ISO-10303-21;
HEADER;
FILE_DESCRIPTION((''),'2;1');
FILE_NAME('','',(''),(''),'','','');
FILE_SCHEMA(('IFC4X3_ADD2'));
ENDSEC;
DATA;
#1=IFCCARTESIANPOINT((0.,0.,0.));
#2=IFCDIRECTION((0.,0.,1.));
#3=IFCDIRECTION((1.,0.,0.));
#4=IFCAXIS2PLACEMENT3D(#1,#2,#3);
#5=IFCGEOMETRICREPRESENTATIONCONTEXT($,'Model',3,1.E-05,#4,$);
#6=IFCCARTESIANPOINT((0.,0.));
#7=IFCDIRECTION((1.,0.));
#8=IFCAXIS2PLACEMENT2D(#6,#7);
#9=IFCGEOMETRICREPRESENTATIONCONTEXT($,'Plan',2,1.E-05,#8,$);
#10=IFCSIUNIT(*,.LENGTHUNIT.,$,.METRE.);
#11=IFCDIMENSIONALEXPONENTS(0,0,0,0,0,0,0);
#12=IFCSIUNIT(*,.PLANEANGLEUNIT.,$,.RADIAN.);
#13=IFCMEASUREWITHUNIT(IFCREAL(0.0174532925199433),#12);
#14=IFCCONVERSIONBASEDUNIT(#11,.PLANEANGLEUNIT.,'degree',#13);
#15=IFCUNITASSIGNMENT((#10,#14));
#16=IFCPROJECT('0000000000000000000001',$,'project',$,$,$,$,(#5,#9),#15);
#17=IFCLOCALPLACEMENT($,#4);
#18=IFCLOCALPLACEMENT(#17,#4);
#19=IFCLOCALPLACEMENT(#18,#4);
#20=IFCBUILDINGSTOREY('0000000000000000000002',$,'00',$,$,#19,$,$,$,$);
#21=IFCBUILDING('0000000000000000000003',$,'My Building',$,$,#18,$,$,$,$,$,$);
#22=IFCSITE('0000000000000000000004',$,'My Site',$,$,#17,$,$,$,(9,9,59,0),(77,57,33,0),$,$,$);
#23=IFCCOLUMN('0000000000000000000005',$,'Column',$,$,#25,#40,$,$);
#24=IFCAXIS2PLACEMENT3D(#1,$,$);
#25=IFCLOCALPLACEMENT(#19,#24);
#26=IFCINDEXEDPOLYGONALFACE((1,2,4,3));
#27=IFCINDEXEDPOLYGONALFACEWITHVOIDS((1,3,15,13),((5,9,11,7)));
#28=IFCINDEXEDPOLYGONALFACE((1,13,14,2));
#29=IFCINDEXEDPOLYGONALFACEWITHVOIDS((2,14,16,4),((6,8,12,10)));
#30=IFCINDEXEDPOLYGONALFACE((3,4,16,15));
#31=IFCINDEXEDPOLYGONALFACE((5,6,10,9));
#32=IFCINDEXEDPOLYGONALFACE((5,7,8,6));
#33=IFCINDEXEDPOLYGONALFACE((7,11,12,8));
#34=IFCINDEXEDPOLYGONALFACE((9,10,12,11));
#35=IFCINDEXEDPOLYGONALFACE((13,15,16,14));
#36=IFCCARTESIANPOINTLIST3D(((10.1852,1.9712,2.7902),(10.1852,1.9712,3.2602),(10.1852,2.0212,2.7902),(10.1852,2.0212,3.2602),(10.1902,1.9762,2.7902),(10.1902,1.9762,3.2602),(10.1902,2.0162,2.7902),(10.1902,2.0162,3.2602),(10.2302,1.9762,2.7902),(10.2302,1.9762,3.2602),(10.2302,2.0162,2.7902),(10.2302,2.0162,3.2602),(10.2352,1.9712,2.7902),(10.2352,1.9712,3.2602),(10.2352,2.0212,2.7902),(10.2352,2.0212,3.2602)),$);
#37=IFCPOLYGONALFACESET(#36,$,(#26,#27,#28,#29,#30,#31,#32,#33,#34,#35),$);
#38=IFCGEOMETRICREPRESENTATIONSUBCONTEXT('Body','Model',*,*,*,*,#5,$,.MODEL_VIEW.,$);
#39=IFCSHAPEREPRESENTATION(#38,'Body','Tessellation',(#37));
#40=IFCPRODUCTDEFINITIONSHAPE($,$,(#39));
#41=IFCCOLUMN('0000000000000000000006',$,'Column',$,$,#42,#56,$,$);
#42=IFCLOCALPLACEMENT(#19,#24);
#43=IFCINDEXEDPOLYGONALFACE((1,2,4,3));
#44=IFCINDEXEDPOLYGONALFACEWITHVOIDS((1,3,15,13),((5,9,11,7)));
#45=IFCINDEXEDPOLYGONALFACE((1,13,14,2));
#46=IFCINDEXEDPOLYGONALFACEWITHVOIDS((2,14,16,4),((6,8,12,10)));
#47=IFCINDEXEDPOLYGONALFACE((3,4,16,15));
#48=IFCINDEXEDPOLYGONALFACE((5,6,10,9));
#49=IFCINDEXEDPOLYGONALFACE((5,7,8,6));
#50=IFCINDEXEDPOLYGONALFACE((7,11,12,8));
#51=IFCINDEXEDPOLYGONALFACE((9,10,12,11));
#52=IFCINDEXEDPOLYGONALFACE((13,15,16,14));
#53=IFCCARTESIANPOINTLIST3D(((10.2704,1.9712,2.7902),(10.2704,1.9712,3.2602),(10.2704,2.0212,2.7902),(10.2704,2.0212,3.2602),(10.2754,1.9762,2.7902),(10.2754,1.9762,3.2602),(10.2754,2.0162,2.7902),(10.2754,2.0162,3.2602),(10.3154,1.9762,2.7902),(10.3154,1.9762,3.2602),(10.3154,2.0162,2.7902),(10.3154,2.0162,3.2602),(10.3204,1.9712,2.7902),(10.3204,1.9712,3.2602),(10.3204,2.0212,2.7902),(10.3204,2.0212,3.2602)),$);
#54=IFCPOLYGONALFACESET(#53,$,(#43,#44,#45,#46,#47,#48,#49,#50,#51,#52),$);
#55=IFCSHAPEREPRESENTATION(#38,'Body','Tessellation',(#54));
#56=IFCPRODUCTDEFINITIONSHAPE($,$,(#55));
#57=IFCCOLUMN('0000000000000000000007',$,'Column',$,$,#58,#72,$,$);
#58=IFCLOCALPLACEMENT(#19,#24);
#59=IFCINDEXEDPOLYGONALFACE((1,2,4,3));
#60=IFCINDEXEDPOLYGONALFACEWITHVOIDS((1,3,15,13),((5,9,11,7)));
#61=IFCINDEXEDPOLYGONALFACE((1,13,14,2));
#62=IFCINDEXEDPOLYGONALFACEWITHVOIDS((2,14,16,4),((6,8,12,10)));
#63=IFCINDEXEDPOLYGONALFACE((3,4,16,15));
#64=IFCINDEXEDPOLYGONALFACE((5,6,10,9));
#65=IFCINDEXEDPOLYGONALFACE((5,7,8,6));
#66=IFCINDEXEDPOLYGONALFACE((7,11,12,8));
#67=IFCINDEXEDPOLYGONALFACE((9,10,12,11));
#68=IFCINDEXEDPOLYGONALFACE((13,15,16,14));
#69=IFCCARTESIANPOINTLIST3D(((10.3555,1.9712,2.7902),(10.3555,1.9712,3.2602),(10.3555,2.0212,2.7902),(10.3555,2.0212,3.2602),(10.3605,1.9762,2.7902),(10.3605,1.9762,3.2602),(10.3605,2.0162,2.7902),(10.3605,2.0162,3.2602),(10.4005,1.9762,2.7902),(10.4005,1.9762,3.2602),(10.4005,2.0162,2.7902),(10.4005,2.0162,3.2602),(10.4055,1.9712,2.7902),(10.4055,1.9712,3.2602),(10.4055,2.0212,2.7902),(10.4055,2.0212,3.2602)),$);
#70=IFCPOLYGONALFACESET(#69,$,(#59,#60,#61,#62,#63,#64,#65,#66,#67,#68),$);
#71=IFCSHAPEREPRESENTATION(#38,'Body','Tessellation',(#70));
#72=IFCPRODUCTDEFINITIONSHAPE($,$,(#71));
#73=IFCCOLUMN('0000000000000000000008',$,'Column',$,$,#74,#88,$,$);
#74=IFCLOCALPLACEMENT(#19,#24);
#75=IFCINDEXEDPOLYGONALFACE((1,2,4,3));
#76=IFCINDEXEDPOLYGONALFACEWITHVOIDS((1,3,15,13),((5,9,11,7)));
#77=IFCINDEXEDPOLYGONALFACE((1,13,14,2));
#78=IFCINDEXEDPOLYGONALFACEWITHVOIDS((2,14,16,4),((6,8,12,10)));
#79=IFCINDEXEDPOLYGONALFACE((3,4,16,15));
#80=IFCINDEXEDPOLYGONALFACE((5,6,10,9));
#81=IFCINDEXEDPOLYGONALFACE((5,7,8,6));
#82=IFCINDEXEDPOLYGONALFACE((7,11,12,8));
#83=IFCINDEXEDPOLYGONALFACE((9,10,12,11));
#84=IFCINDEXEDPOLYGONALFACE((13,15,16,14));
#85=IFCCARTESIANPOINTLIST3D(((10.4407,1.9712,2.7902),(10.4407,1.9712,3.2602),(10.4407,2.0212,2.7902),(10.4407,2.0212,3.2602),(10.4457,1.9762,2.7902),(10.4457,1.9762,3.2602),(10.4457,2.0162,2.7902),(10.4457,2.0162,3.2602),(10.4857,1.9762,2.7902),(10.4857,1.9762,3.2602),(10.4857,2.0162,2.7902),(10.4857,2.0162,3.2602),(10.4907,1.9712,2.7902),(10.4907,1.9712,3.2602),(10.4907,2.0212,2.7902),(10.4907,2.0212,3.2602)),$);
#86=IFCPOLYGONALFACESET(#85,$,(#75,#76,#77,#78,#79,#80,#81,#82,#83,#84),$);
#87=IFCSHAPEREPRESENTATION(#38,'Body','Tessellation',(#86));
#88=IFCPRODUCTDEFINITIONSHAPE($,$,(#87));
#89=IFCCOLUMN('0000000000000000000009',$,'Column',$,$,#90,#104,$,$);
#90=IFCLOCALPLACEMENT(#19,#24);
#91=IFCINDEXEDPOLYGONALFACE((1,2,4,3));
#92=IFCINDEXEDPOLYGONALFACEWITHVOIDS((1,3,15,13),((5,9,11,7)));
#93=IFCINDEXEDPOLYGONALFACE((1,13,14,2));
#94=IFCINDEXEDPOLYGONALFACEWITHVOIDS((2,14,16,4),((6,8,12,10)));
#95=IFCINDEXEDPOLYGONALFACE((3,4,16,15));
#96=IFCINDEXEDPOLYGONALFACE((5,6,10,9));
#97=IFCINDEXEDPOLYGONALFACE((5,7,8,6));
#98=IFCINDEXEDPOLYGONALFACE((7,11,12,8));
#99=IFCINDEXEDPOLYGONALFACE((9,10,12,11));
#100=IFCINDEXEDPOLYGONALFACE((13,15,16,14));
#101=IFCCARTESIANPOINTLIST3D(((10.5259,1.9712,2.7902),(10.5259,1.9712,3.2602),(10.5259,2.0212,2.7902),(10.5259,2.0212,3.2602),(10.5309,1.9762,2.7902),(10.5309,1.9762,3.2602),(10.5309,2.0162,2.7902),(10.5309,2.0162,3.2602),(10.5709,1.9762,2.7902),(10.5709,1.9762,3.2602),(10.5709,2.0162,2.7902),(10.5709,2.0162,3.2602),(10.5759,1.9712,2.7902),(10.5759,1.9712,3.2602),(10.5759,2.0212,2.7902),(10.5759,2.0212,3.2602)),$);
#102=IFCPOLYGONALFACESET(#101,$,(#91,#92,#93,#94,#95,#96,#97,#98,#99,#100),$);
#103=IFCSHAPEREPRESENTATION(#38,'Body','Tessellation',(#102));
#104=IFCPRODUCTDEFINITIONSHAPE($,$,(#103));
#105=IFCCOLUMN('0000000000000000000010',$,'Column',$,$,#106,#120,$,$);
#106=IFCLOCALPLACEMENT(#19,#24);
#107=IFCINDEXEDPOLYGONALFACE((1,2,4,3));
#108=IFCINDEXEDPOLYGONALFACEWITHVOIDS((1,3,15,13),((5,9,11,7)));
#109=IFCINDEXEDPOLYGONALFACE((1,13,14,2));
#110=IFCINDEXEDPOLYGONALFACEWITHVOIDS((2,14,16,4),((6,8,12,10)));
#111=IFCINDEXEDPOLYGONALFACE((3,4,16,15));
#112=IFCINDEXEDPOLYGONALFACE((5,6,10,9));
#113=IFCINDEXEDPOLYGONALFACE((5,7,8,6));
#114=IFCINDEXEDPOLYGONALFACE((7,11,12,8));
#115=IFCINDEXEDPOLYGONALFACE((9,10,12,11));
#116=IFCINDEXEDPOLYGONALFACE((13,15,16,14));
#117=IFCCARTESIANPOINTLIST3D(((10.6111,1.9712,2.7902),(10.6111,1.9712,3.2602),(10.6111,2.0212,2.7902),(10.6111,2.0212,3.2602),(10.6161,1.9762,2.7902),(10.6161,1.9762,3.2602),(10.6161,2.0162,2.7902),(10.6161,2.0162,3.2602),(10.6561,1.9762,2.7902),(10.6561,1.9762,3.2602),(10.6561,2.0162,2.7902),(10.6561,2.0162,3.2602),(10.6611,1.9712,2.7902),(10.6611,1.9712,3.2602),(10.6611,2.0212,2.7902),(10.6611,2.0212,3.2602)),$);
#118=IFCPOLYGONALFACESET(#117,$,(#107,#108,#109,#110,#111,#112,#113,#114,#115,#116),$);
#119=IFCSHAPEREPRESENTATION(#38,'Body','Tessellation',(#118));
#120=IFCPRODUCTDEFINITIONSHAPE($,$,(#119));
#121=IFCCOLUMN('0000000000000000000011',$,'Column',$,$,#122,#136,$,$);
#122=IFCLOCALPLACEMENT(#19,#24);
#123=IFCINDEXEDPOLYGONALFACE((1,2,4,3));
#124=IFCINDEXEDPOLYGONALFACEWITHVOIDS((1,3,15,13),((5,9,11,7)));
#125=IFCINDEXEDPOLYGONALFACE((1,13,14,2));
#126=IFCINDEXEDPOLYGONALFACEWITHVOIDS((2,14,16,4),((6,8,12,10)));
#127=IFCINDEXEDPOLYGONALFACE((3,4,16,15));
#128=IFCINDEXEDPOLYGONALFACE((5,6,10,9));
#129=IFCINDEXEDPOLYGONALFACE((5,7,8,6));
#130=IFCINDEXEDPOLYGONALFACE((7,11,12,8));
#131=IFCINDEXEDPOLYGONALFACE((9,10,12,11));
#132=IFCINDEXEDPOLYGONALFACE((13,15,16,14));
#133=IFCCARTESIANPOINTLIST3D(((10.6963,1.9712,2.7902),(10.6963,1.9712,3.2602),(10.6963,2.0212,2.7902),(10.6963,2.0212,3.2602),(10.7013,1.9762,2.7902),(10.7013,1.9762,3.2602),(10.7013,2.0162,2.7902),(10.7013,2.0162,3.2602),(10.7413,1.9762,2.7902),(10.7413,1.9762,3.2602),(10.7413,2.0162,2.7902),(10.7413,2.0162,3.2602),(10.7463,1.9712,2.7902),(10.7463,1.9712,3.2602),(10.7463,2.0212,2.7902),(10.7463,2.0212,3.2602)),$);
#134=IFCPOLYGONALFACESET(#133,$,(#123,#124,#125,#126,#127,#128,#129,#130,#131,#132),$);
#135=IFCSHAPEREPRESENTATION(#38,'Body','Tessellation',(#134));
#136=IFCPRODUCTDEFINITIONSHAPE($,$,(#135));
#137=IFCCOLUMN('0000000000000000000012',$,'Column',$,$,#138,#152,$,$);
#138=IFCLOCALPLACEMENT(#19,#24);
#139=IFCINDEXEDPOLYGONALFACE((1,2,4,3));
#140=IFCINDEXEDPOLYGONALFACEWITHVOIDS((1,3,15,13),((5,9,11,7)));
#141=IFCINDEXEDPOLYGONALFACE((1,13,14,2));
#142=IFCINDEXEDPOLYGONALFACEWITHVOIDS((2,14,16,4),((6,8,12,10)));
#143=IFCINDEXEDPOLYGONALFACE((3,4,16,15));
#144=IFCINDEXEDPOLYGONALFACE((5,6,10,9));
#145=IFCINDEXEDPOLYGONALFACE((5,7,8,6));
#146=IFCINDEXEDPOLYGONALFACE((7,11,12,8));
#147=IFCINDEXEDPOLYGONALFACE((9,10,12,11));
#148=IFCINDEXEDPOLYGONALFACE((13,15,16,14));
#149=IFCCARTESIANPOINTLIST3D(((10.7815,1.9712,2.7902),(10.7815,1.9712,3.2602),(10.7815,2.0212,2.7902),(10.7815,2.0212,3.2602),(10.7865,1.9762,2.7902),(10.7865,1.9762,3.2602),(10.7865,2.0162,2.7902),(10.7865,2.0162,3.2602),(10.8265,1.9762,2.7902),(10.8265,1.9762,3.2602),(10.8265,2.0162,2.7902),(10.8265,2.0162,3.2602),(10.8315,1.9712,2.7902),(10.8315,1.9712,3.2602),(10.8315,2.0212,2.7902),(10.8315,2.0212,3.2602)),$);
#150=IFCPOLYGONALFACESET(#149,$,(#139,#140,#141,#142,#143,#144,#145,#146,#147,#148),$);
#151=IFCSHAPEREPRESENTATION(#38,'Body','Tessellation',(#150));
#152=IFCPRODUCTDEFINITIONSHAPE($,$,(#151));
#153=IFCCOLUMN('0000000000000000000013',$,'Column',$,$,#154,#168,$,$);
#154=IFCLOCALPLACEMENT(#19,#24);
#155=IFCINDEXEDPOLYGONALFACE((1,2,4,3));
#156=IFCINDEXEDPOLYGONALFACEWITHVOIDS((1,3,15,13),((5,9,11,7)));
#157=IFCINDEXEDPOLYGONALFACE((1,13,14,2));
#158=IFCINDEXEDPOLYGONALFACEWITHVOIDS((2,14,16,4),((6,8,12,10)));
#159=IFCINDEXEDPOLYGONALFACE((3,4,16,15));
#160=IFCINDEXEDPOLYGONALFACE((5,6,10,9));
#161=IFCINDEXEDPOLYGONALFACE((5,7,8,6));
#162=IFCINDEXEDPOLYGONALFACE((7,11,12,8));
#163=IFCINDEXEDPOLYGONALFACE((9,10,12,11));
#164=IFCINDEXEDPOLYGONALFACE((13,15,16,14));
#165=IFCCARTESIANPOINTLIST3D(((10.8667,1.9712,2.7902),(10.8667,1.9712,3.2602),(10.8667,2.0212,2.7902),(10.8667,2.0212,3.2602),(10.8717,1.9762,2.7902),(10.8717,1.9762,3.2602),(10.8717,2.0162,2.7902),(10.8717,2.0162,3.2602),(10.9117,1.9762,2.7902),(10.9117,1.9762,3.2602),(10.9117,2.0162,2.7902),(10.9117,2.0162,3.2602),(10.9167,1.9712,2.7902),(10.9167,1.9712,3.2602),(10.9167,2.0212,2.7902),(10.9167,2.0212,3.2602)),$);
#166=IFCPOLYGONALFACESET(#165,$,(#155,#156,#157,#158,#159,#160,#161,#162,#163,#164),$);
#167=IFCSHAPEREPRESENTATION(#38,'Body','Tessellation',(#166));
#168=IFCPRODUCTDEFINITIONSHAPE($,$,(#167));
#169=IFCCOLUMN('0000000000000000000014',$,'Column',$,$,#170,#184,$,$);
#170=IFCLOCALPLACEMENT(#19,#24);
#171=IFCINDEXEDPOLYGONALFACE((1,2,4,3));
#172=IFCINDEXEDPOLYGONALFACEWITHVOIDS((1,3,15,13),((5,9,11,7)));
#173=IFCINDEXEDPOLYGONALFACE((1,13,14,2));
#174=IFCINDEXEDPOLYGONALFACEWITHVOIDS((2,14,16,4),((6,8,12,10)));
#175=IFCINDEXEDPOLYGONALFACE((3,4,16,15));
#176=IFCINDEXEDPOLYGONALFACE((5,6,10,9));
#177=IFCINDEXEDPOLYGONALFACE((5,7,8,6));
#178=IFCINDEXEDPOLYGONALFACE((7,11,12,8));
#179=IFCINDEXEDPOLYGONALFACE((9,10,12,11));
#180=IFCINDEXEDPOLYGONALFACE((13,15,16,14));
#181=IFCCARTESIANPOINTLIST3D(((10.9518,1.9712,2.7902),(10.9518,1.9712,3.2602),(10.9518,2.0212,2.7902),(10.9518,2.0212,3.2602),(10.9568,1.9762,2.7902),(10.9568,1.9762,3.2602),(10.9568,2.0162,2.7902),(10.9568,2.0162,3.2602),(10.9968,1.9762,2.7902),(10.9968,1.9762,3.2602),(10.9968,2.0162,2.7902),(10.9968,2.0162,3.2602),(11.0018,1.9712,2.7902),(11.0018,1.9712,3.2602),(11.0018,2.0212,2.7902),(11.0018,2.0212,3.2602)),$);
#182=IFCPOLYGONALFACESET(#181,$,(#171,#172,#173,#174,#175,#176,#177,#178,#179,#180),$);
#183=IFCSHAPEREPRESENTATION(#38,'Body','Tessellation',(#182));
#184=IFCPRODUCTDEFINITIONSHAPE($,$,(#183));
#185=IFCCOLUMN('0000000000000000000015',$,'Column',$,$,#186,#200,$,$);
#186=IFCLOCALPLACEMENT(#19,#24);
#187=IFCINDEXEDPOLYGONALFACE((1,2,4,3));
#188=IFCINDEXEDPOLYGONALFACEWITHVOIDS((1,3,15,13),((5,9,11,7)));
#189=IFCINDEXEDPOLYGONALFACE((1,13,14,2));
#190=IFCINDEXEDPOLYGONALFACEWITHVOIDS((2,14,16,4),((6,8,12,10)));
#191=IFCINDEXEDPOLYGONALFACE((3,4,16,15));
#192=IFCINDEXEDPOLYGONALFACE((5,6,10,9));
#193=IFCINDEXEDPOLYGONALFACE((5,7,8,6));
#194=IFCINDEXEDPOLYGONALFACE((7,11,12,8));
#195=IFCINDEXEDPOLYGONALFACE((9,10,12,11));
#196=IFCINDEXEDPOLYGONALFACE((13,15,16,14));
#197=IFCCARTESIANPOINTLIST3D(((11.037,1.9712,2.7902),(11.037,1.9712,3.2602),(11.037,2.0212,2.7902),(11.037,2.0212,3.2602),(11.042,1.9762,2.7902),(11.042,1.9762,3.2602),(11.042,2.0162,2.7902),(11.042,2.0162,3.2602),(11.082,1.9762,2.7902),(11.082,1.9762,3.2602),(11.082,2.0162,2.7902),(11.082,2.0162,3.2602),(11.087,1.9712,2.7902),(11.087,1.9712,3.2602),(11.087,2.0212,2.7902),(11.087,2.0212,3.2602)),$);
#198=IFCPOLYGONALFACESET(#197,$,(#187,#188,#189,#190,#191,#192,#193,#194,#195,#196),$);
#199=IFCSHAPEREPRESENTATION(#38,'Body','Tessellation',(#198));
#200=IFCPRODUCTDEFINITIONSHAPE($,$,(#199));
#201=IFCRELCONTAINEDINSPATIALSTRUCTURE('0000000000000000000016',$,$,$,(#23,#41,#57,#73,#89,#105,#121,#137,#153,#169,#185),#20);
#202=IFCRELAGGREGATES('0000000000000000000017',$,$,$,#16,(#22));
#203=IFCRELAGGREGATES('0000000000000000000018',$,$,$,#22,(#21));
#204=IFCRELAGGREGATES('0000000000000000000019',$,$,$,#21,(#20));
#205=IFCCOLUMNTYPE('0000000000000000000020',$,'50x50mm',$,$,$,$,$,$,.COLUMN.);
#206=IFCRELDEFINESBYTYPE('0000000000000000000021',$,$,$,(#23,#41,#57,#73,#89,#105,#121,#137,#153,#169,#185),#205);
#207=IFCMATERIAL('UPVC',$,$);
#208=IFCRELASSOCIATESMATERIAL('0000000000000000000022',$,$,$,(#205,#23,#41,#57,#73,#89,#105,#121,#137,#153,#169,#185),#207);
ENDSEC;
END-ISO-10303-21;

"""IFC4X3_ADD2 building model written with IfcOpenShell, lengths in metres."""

from ifc_helpers import new_model, entity, si_unit, converted_unit, frame, origin_with_axes, origin_2d_with_axis, place, context, subcontext, project, spatial, hollow_rectangle, extrude, material, material_profile, profile_set, profile_usage, type_object, element, save


model = new_model("IFC4X3_ADD2")

# Units and contexts
model_context = context("Model", 3, precision=1e-05, world=origin_with_axes())
plan_context = context("Plan", 2, precision=1e-05, world=origin_2d_with_axis())
body_context = subcontext(model_context, "Body", "Model", "MODEL_VIEW")
ifc_project = project(units=[si_unit("LENGTHUNIT", "METRE"), converted_unit("PLANEANGLEUNIT", "degree", entity("IfcReal", 0.0174532925199433), si_unit("PLANEANGLEUNIT", "RADIAN"), dimensions=[0, 0, 0, 0, 0, 0, 0])], contexts=[model_context, plan_context])

# Site, building, storey
site_placement = place(None, origin_with_axes())
site = spatial("IfcSite", under=ifc_project, at=site_placement, Name="My Site", RefLatitude=(9, 9, 59, 0), RefLongitude=(77, 57, 33, 0))
building_placement = place(site_placement, origin_with_axes())
building = spatial("IfcBuilding", under=site, at=building_placement, Name="My Building")
storey_placement = place(building_placement, origin_with_axes())
storey = spatial("IfcBuildingStorey", under=building, at=storey_placement, Name="00")

# Columns
ifc_material_1 = material(Name="UPVC")
ifc_material_profile_1 = material_profile(ifc_material_1, hollow_rectangle(XDim=0.05, YDim=0.05, WallThickness=0.005))
ifc_profile_set_1 = profile_set([ifc_material_profile_1])
ifc_profile_usage_1 = profile_usage(ifc_profile_set_1, cardinal=5)
column_type = type_object("IfcColumnType", Name="50x50mm", PredefinedType="COLUMN", material=ifc_profile_set_1)
column_1_placement = place(storey_placement, frame((10.2102, 1.9962, 2.7902), z_axis=(0.0, 0.0, 1.0), x_axis=(1.0, 0.0, 0.0)))
element("IfcColumn", 1, at=column_1_placement, inside=storey, type_object=column_type, material=ifc_profile_usage_1, Name="Column", context=body_context, shape_type="SweptSolid", body=[
    extrude(hollow_rectangle(XDim=0.05, YDim=0.05, WallThickness=0.005), origin_with_axes(), (0.0, 0.0, 1.0), 0.47),
])
ifc_profile_usage_2 = profile_usage(ifc_profile_set_1, cardinal=5)
column_2_placement = place(storey_placement, frame((10.2954, 1.9962, 2.7902), z_axis=(0.0, 0.0, 1.0), x_axis=(1.0, 0.0, 0.0)))
element("IfcColumn", 2, at=column_2_placement, inside=storey, type_object=column_type, material=ifc_profile_usage_2, Name="Column", context=body_context, shape_type="SweptSolid", body=[
    extrude(hollow_rectangle(XDim=0.05, YDim=0.05, WallThickness=0.005), origin_with_axes(), (0.0, 0.0, 1.0), 0.47),
])
ifc_profile_usage_3 = profile_usage(ifc_profile_set_1, cardinal=5)
column_3_placement = place(storey_placement, frame((10.3805, 1.9962, 2.7902), z_axis=(0.0, 0.0, 1.0), x_axis=(1.0, 0.0, 0.0)))
element("IfcColumn", 3, at=column_3_placement, inside=storey, type_object=column_type, material=ifc_profile_usage_3, Name="Column", context=body_context, shape_type="SweptSolid", body=[
    extrude(hollow_rectangle(XDim=0.05, YDim=0.05, WallThickness=0.005), origin_with_axes(), (0.0, 0.0, 1.0), 0.47),
])
ifc_profile_usage_4 = profile_usage(ifc_profile_set_1, cardinal=5)
column_4_placement = place(storey_placement, frame((10.4657, 1.9962, 2.7902), z_axis=(0.0, 0.0, 1.0), x_axis=(1.0, 0.0, 0.0)))
element("IfcColumn", 4, at=column_4_placement, inside=storey, type_object=column_type, material=ifc_profile_usage_4, Name="Column", context=body_context, shape_type="SweptSolid", body=[
    extrude(hollow_rectangle(XDim=0.05, YDim=0.05, WallThickness=0.005), origin_with_axes(), (0.0, 0.0, 1.0), 0.47),
])
ifc_profile_usage_5 = profile_usage(ifc_profile_set_1, cardinal=5)
column_5_placement = place(storey_placement, frame((10.5509, 1.9962, 2.7902), z_axis=(0.0, 0.0, 1.0), x_axis=(1.0, 0.0, 0.0)))
element("IfcColumn", 5, at=column_5_placement, inside=storey, type_object=column_type, material=ifc_profile_usage_5, Name="Column", context=body_context, shape_type="SweptSolid", body=[
    extrude(hollow_rectangle(XDim=0.05, YDim=0.05, WallThickness=0.005), origin_with_axes(), (0.0, 0.0, 1.0), 0.47),
])
ifc_profile_usage_6 = profile_usage(ifc_profile_set_1, cardinal=5)
column_6_placement = place(storey_placement, frame((10.6361, 1.9962, 2.7902), z_axis=(0.0, 0.0, 1.0), x_axis=(1.0, 0.0, 0.0)))
element("IfcColumn", 6, at=column_6_placement, inside=storey, type_object=column_type, material=ifc_profile_usage_6, Name="Column", context=body_context, shape_type="SweptSolid", body=[
    extrude(hollow_rectangle(XDim=0.05, YDim=0.05, WallThickness=0.005), origin_with_axes(), (0.0, 0.0, 1.0), 0.47),
])
ifc_profile_usage_7 = profile_usage(ifc_profile_set_1, cardinal=5)
column_7_placement = place(storey_placement, frame((10.7213, 1.9962, 2.7902), z_axis=(0.0, 0.0, 1.0), x_axis=(1.0, 0.0, 0.0)))
element("IfcColumn", 7, at=column_7_placement, inside=storey, type_object=column_type, material=ifc_profile_usage_7, Name="Column", context=body_context, shape_type="SweptSolid", body=[
    extrude(hollow_rectangle(XDim=0.05, YDim=0.05, WallThickness=0.005), origin_with_axes(), (0.0, 0.0, 1.0), 0.47),
])
ifc_profile_usage_8 = profile_usage(ifc_profile_set_1, cardinal=5)
column_8_placement = place(storey_placement, frame((10.8065, 1.9962, 2.7902), z_axis=(0.0, 0.0, 1.0), x_axis=(1.0, 0.0, 0.0)))
element("IfcColumn", 8, at=column_8_placement, inside=storey, type_object=column_type, material=ifc_profile_usage_8, Name="Column", context=body_context, shape_type="SweptSolid", body=[
    extrude(hollow_rectangle(XDim=0.05, YDim=0.05, WallThickness=0.005), origin_with_axes(), (0.0, 0.0, 1.0), 0.47),
])
ifc_profile_usage_9 = profile_usage(ifc_profile_set_1, cardinal=5)
column_9_placement = place(storey_placement, frame((10.8917, 1.9962, 2.7902), z_axis=(0.0, 0.0, 1.0), x_axis=(1.0, 0.0, 0.0)))
element("IfcColumn", 9, at=column_9_placement, inside=storey, type_object=column_type, material=ifc_profile_usage_9, Name="Column", context=body_context, shape_type="SweptSolid", body=[
    extrude(hollow_rectangle(XDim=0.05, YDim=0.05, WallThickness=0.005), origin_with_axes(), (0.0, 0.0, 1.0), 0.47),
])
ifc_profile_usage_10 = profile_usage(ifc_profile_set_1, cardinal=5)
column_10_placement = place(storey_placement, frame((10.9768, 1.9962, 2.7902), z_axis=(0.0, 0.0, 1.0), x_axis=(1.0, 0.0, 0.0)))
element("IfcColumn", 10, at=column_10_placement, inside=storey, type_object=column_type, material=ifc_profile_usage_10, Name="Column", context=body_context, shape_type="SweptSolid", body=[
    extrude(hollow_rectangle(XDim=0.05, YDim=0.05, WallThickness=0.005), origin_with_axes(), (0.0, 0.0, 1.0), 0.47),
])
ifc_profile_usage_11 = profile_usage(ifc_profile_set_1, cardinal=5)
column_11_placement = place(storey_placement, frame((11.062, 1.9962, 2.7902), z_axis=(0.0, 0.0, 1.0), x_axis=(1.0, 0.0, 0.0)))
element("IfcColumn", 11, at=column_11_placement, inside=storey, type_object=column_type, material=ifc_profile_usage_11, Name="Column", context=body_context, shape_type="SweptSolid", body=[
    extrude(hollow_rectangle(XDim=0.05, YDim=0.05, WallThickness=0.005), origin_with_axes(), (0.0, 0.0, 1.0), 0.47),
])

save(model, "model.ifc")
